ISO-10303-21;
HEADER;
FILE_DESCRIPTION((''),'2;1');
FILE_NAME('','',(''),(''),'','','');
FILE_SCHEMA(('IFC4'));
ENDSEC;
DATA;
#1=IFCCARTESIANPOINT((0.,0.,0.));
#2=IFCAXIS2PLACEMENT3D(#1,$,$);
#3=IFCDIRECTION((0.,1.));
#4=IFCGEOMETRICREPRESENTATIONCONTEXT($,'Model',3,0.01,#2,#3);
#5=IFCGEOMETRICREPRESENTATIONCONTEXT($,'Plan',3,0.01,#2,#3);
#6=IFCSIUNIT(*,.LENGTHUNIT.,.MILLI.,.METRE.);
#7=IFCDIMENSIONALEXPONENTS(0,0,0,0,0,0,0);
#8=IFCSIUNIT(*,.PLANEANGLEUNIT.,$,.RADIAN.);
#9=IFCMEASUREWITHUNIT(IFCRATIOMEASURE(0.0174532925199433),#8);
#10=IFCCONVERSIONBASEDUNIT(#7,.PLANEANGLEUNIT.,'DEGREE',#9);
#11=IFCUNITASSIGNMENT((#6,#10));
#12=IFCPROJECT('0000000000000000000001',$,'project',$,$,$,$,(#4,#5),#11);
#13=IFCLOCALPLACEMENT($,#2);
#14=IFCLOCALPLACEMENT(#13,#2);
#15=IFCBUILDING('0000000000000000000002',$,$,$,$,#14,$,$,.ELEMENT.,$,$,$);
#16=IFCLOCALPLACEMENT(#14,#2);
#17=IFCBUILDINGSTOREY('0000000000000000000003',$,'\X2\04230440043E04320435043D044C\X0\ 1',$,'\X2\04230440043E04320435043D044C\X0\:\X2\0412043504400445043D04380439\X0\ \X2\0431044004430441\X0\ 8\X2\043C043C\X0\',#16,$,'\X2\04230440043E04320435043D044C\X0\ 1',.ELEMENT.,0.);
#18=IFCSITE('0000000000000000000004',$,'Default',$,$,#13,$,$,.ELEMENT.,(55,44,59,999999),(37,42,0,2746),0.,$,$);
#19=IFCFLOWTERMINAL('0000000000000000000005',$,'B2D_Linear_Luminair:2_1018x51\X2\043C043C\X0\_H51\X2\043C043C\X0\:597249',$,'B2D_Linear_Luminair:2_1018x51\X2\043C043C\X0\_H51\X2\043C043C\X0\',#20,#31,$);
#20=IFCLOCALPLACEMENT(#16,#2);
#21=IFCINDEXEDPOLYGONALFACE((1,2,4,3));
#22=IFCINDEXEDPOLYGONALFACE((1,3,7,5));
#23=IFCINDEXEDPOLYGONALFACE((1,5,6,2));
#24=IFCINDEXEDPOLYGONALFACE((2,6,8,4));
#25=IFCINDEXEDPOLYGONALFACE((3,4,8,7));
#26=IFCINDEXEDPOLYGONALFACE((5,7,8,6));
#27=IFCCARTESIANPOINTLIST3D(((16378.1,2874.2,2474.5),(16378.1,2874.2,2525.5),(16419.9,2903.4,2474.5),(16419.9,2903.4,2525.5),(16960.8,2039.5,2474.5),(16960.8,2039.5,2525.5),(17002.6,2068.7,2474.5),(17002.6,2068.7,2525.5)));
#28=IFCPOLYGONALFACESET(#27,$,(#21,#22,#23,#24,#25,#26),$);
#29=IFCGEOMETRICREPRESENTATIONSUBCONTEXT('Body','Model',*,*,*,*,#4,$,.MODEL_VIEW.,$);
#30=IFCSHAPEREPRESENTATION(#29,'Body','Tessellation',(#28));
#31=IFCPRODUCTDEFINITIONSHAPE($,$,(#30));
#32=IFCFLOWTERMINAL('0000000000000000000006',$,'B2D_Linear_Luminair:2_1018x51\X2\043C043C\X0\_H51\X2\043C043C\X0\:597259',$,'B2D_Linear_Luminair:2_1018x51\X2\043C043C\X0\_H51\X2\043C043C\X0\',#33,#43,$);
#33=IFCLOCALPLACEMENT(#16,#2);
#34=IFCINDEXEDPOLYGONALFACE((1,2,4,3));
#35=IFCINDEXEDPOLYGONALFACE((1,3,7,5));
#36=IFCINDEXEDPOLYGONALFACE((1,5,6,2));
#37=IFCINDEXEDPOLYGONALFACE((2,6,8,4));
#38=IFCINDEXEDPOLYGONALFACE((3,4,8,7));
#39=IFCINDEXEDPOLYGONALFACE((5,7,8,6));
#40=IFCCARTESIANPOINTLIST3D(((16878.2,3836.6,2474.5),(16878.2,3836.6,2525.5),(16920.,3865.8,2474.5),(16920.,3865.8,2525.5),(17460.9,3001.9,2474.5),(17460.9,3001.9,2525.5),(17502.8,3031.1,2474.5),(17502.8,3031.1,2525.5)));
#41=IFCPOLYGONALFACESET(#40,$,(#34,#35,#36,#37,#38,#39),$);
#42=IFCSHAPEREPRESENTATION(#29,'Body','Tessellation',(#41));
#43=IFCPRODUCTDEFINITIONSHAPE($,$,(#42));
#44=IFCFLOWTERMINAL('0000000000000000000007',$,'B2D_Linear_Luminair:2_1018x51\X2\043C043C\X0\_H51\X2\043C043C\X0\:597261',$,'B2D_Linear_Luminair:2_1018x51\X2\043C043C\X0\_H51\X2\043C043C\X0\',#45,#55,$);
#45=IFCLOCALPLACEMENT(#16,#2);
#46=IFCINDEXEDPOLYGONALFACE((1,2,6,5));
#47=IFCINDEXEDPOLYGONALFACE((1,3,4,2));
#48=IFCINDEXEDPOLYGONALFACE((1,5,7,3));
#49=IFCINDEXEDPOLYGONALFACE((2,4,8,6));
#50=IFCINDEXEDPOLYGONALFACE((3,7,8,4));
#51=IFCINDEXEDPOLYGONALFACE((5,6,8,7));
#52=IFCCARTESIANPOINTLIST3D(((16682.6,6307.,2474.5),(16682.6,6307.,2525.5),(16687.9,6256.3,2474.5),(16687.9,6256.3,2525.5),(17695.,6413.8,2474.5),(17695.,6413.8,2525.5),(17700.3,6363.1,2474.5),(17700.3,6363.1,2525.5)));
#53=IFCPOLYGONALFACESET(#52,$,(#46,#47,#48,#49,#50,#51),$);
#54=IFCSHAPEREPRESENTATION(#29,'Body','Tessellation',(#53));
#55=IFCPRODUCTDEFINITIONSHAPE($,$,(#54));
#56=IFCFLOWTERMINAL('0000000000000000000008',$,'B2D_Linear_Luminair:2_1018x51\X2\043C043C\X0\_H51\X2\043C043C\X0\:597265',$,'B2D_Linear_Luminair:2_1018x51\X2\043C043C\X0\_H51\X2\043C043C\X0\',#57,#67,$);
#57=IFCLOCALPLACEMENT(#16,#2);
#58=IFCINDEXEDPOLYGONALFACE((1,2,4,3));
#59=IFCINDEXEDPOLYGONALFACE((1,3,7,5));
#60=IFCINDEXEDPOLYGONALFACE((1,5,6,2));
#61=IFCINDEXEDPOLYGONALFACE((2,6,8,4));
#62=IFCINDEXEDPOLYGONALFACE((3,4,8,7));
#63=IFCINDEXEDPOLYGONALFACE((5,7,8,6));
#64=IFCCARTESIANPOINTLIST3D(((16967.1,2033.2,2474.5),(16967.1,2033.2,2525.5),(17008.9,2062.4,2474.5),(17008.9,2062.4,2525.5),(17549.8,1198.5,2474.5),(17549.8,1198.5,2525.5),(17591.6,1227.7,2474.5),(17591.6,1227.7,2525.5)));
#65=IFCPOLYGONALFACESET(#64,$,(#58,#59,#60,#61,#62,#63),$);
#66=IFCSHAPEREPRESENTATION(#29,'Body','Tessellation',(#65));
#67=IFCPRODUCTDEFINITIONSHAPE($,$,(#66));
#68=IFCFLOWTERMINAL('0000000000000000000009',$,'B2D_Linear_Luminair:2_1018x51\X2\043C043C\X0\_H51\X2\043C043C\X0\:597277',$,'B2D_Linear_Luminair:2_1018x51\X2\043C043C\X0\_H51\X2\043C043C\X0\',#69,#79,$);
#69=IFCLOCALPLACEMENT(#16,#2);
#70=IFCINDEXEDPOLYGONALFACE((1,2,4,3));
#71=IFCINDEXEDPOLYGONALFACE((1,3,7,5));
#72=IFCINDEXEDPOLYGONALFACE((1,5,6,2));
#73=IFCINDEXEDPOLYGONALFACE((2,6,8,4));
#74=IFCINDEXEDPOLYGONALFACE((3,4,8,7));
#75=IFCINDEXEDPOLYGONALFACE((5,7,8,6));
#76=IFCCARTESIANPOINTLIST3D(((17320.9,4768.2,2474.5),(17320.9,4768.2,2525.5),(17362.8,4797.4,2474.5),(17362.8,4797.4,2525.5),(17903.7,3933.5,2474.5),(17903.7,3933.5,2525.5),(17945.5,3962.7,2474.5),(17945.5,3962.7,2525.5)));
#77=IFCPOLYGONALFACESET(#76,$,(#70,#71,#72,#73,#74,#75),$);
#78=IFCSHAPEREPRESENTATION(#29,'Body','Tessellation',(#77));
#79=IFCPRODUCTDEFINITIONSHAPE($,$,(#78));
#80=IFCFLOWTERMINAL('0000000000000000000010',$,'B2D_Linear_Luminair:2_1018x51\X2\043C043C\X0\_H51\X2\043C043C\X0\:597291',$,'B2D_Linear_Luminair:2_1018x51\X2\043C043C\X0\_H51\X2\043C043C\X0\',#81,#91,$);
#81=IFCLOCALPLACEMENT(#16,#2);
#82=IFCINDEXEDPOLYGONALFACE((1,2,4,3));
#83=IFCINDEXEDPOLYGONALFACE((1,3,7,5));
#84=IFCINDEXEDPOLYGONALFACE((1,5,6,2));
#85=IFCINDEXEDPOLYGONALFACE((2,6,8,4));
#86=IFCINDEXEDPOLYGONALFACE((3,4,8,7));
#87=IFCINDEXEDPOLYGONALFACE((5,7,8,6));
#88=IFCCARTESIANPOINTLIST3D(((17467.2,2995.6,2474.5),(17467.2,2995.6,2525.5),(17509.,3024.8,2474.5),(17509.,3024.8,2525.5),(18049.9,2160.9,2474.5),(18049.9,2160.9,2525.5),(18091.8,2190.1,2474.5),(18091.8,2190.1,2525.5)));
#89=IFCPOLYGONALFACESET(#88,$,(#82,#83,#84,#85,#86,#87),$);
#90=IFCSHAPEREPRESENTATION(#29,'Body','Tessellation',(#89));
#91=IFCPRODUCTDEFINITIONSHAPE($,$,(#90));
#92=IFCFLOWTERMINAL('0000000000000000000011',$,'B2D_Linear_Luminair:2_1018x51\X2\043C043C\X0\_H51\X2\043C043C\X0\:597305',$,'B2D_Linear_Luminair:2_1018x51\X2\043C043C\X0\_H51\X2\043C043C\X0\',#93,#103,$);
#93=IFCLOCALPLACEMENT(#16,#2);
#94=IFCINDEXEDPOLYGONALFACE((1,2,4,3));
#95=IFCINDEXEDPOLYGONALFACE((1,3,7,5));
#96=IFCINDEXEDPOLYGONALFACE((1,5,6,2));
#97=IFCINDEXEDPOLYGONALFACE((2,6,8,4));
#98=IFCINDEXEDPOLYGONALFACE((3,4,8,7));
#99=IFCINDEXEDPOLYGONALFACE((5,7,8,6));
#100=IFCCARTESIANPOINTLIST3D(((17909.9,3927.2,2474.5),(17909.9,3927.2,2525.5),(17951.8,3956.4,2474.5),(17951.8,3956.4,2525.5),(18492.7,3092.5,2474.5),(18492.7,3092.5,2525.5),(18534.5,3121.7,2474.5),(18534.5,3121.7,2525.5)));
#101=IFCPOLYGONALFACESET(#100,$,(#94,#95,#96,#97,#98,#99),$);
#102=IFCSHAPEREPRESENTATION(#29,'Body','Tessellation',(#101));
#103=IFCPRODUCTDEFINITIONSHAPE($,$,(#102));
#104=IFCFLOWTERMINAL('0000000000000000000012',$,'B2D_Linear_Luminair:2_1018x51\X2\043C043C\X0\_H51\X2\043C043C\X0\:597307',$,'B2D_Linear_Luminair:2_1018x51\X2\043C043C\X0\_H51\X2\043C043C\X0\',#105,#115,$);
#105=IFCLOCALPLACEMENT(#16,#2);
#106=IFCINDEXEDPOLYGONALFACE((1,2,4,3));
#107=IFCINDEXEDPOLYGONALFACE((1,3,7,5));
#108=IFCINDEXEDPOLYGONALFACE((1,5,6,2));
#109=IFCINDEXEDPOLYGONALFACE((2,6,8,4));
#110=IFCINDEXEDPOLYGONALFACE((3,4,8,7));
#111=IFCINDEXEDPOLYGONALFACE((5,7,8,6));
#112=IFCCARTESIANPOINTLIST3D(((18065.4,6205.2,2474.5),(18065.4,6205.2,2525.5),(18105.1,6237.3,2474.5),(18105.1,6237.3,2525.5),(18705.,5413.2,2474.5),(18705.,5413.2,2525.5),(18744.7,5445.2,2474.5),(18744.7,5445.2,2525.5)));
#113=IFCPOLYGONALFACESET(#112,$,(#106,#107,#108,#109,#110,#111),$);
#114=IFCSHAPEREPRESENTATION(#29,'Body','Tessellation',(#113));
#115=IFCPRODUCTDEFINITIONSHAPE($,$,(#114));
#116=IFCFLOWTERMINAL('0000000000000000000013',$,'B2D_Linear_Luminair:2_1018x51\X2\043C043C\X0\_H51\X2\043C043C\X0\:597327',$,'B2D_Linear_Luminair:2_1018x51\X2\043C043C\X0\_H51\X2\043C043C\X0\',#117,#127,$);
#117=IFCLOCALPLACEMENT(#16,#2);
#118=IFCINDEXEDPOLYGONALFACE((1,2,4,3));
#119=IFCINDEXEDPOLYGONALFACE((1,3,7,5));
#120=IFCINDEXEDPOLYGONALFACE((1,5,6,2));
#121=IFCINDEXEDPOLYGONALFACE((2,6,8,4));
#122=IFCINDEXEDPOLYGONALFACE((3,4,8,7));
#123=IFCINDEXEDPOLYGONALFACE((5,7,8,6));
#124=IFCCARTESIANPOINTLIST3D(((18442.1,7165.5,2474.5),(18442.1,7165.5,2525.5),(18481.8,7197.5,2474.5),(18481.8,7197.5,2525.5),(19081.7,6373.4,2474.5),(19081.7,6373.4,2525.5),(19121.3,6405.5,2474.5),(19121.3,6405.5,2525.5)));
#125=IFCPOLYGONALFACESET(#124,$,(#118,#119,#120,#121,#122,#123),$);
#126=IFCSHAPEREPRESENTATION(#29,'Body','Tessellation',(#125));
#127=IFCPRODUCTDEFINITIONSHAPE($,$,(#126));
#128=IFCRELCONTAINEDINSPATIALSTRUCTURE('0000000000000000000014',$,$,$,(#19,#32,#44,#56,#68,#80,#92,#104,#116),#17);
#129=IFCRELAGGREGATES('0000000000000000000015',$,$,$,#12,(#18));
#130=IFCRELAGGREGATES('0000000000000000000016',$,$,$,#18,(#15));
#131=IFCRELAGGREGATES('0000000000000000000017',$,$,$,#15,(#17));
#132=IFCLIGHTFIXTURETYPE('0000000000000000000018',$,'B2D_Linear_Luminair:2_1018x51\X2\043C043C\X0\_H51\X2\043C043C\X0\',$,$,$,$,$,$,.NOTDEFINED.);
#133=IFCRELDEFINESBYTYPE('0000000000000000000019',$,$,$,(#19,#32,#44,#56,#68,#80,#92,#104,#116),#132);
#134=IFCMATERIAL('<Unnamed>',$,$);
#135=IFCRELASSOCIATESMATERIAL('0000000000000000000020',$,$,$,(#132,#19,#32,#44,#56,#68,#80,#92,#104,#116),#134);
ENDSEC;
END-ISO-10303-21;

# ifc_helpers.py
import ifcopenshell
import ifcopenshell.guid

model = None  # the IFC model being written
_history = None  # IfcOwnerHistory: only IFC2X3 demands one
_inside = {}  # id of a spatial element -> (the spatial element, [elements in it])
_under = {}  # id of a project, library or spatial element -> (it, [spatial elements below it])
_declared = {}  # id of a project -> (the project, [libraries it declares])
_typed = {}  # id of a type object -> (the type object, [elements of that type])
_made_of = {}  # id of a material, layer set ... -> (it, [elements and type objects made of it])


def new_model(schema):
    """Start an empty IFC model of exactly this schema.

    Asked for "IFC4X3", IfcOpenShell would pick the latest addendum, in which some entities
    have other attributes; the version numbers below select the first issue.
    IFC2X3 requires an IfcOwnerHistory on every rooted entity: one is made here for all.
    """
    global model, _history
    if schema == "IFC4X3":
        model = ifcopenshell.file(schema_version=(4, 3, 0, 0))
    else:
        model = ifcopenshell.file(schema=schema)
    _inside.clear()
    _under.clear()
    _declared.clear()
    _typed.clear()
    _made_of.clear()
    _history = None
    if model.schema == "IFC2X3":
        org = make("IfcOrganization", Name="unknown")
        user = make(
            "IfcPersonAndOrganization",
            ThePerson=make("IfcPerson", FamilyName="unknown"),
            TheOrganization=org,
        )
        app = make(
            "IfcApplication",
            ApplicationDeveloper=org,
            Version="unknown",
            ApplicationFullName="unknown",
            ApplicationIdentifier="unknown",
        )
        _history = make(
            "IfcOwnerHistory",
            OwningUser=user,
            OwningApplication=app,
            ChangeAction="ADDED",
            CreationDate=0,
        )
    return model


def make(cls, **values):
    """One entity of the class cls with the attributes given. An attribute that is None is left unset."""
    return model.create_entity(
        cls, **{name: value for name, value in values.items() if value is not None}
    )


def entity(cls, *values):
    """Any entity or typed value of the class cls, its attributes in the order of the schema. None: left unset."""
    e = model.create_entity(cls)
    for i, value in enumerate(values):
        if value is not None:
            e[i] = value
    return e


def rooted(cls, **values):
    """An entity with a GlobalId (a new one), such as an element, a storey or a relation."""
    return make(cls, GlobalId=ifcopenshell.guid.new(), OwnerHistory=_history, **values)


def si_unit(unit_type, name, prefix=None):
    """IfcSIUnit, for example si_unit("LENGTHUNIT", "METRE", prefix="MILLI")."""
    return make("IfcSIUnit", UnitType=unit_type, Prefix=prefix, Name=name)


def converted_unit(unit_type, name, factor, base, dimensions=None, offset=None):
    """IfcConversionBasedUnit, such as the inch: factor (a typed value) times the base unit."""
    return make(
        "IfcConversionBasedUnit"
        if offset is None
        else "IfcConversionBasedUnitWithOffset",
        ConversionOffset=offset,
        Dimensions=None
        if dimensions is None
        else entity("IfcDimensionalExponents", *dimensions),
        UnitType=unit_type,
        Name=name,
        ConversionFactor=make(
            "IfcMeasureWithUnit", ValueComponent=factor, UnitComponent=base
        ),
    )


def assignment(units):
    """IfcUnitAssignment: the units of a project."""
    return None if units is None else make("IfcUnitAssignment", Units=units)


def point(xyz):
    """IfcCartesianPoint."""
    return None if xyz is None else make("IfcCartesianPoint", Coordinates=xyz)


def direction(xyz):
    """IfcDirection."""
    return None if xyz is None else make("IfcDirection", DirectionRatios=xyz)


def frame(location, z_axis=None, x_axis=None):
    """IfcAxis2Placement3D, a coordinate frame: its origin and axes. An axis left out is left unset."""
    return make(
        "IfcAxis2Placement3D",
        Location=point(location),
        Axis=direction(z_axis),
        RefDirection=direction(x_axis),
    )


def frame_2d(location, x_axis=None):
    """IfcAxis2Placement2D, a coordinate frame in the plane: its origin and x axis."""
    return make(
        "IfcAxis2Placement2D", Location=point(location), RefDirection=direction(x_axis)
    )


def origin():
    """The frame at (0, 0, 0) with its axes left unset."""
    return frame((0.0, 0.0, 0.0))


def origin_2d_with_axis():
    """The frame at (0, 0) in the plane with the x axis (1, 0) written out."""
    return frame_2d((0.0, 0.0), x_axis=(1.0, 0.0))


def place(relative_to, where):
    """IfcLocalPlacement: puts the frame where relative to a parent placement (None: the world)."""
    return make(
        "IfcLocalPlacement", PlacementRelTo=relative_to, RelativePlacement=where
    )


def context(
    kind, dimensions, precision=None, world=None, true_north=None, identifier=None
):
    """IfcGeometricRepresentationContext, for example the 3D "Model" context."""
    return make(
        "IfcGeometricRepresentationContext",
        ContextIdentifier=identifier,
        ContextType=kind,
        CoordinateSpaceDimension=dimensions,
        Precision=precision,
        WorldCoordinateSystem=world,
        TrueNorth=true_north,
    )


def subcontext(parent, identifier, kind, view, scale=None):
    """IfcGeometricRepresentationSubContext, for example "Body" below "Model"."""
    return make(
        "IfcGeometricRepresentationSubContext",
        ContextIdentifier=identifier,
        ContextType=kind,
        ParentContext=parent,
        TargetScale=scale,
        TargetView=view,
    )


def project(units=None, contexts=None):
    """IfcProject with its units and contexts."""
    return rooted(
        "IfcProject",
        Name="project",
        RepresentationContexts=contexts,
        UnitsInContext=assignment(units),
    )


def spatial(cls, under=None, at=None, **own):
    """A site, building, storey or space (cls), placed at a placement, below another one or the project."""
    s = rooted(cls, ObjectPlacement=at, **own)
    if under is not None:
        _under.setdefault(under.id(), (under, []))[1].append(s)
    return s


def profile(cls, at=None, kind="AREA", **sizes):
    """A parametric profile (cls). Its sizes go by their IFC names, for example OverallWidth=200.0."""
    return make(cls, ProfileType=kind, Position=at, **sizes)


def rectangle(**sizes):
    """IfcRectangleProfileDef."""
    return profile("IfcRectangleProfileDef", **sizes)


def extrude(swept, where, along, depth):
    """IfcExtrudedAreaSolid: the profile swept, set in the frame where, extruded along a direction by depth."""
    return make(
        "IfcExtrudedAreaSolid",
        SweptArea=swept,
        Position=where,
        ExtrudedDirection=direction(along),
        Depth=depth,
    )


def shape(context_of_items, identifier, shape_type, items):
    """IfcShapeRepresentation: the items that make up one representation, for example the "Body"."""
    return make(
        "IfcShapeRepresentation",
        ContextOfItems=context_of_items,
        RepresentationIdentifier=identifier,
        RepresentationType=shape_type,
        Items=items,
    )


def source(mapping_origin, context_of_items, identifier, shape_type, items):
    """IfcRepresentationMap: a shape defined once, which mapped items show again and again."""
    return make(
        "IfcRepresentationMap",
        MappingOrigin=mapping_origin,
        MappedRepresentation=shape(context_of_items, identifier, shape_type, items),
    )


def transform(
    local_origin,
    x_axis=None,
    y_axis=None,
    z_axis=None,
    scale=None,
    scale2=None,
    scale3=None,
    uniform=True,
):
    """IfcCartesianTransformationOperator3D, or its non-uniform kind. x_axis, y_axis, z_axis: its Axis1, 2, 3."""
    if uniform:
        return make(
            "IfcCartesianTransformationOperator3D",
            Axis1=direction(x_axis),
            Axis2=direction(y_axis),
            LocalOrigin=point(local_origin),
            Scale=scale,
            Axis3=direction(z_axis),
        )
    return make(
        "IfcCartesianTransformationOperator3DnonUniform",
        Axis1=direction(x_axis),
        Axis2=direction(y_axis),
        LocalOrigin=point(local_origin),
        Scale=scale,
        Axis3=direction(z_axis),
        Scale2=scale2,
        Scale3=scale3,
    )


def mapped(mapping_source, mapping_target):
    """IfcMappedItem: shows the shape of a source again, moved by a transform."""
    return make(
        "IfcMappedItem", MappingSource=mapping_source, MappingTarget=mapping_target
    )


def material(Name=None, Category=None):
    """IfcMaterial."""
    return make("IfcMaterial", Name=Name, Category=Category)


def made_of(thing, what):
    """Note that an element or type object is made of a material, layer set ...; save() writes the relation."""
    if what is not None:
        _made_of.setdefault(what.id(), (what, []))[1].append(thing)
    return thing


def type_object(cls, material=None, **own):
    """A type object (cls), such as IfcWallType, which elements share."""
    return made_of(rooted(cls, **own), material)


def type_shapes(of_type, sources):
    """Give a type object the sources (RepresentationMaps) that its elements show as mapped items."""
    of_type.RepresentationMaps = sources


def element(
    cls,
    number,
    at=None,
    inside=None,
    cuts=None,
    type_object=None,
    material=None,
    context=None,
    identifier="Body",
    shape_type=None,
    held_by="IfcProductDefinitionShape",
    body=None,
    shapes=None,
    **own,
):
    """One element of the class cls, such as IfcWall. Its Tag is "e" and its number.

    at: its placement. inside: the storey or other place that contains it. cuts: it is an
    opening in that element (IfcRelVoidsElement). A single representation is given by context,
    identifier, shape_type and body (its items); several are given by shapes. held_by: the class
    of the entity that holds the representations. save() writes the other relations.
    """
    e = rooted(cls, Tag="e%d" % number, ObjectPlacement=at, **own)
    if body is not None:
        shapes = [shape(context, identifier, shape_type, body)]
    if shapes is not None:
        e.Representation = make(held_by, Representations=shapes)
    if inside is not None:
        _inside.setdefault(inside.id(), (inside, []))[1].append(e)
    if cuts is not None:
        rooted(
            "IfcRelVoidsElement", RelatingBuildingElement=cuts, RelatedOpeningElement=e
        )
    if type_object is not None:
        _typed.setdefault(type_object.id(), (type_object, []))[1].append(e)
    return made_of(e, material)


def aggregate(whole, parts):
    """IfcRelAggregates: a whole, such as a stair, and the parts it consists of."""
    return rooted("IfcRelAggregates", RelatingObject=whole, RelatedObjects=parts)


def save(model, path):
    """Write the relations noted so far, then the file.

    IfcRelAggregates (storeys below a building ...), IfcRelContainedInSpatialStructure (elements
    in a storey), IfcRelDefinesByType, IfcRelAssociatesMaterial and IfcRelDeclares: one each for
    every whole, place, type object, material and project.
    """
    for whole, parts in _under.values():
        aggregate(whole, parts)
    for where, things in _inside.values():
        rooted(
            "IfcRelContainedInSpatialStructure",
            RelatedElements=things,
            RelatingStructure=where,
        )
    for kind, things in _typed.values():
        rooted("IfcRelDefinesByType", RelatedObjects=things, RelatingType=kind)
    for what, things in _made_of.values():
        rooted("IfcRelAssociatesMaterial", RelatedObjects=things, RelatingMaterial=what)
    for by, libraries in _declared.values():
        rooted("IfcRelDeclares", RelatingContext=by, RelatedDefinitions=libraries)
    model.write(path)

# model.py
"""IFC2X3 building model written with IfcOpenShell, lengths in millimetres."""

from ifc_helpers import new_model, entity, si_unit, converted_unit, direction, frame, origin, origin_2d_with_axis, place, context, subcontext, project, spatial, rectangle, extrude, source, transform, mapped, material, type_object, type_shapes, element, save


model = new_model("IFC2X3")

# Units and contexts
model_context = context("Model", 3, precision=0.01, world=origin(), true_north=direction((0.0, 1.0)))
plan_context = context("Plan", 3, precision=0.01, world=origin(), true_north=direction((0.0, 1.0)))
body_context = subcontext(model_context, "Body", "Model", "MODEL_VIEW")
ifc_project = project(units=[si_unit("LENGTHUNIT", "METRE", prefix="MILLI"), converted_unit("PLANEANGLEUNIT", "DEGREE", entity("IfcRatioMeasure", 0.0174532925199433), si_unit("PLANEANGLEUNIT", "RADIAN"), dimensions=[0, 0, 0, 0, 0, 0, 0])], contexts=[model_context, plan_context])

# Site, building, storey
site_placement = place(None, origin())
site = spatial("IfcSite", under=ifc_project, at=site_placement, Name="Default", CompositionType="ELEMENT", RefLatitude=(55, 44, 59, 999999), RefLongitude=(37, 42, 0, 2746), RefElevation=0.0)
building_placement = place(site_placement, origin())
building = spatial("IfcBuilding", under=site, at=building_placement, CompositionType="ELEMENT")
storey_placement = place(building_placement, origin())
storey = spatial("IfcBuildingStorey", under=building, at=storey_placement, Name="Уровень 1", ObjectType="Уровень:Верхний брус 8мм", LongName="Уровень 1", CompositionType="ELEMENT", Elevation=0.0)

# Flow terminals
ifc_material = material(Name="<Unnamed>")
light_fixture_type_1 = type_object("IfcLightFixtureType", Name="B2D_Linear_Luminair:2_1018x51мм_H51мм", PredefinedType="NOTDEFINED", material=ifc_material)
shared_shape_1 = source(origin(), body_context, "Body", "SweptSolid", [
    extrude(rectangle(XDim=1018.0, YDim=51.0, at=origin_2d_with_axis()), frame((0.0, 0.0, 0.0), z_axis=(0.0, 0.0, 1.0), x_axis=(-1.0, 0.0, 0.0)), (0.0, 0.0, 1.0), 51.0),
])
type_shapes(light_fixture_type_1, [shared_shape_1])
for number, where, z_axis, x_axis, name in (
    (1, (16690.3, 2471.5, 2525.5), (0.0, 0.0, -1.0), (0.572432, -0.819952, 0.0), "B2D_Linear_Luminair:2_1018x51мм_H51мм:597249"),
    (2, (17190.5, 3433.8, 2525.5), (0.0, 0.0, -1.0), (0.572432, -0.819952, 0.0), "B2D_Linear_Luminair:2_1018x51мм_H51мм:597259"),
    (3, (17191.5, 6335.0, 2525.5), (0.0, 0.0, -1.0), (0.994485, 0.104876, 0.0), "B2D_Linear_Luminair:2_1018x51мм_H51мм:597261"),
    (4, (17279.3, 1630.5, 2525.5), (0.0, 0.0, -1.0), (0.572432, -0.819952, 0.0), "B2D_Linear_Luminair:2_1018x51мм_H51мм:597265"),
    (5, (17633.2, 4365.4, 2525.5), (0.0, 0.0, -1.0), (0.572432, -0.819952, 0.0), "B2D_Linear_Luminair:2_1018x51мм_H51мм:597277"),
    (6, (17779.5, 2592.8, 2525.5), (0.0, 0.0, -1.0), (0.572432, -0.819952, 0.0), "B2D_Linear_Luminair:2_1018x51мм_H51мм:597291"),
    (7, (18222.2, 3524.5, 2525.5), (0.0, 0.0, -1.0), (0.572432, -0.819952, 0.0), "B2D_Linear_Luminair:2_1018x51мм_H51мм:597305"),
    (8, (18405.1, 5825.2, 2525.5), (0.0, 0.0, -1.0), (0.628235, -0.778024, 0.0), "B2D_Linear_Luminair:2_1018x51мм_H51мм:597307"),
    (9, (18781.7, 6785.5, 2525.5), (0.0, 0.0, -1.0), (0.628235, -0.778024, 0.0), "B2D_Linear_Luminair:2_1018x51мм_H51мм:597327"),
):
    element("IfcFlowTerminal", number, at=place(storey_placement, frame(where, z_axis=z_axis, x_axis=x_axis)), inside=storey, type_object=light_fixture_type_1, material=ifc_material, Name=name, ObjectType="B2D_Linear_Luminair:2_1018x51мм_H51мм", context=body_context, shape_type="MappedRepresentation", body=[
        mapped(shared_shape_1, transform((0.0, 0.0, 0.0), scale=1.0)),
    ])

save(model, "model.ifc")
